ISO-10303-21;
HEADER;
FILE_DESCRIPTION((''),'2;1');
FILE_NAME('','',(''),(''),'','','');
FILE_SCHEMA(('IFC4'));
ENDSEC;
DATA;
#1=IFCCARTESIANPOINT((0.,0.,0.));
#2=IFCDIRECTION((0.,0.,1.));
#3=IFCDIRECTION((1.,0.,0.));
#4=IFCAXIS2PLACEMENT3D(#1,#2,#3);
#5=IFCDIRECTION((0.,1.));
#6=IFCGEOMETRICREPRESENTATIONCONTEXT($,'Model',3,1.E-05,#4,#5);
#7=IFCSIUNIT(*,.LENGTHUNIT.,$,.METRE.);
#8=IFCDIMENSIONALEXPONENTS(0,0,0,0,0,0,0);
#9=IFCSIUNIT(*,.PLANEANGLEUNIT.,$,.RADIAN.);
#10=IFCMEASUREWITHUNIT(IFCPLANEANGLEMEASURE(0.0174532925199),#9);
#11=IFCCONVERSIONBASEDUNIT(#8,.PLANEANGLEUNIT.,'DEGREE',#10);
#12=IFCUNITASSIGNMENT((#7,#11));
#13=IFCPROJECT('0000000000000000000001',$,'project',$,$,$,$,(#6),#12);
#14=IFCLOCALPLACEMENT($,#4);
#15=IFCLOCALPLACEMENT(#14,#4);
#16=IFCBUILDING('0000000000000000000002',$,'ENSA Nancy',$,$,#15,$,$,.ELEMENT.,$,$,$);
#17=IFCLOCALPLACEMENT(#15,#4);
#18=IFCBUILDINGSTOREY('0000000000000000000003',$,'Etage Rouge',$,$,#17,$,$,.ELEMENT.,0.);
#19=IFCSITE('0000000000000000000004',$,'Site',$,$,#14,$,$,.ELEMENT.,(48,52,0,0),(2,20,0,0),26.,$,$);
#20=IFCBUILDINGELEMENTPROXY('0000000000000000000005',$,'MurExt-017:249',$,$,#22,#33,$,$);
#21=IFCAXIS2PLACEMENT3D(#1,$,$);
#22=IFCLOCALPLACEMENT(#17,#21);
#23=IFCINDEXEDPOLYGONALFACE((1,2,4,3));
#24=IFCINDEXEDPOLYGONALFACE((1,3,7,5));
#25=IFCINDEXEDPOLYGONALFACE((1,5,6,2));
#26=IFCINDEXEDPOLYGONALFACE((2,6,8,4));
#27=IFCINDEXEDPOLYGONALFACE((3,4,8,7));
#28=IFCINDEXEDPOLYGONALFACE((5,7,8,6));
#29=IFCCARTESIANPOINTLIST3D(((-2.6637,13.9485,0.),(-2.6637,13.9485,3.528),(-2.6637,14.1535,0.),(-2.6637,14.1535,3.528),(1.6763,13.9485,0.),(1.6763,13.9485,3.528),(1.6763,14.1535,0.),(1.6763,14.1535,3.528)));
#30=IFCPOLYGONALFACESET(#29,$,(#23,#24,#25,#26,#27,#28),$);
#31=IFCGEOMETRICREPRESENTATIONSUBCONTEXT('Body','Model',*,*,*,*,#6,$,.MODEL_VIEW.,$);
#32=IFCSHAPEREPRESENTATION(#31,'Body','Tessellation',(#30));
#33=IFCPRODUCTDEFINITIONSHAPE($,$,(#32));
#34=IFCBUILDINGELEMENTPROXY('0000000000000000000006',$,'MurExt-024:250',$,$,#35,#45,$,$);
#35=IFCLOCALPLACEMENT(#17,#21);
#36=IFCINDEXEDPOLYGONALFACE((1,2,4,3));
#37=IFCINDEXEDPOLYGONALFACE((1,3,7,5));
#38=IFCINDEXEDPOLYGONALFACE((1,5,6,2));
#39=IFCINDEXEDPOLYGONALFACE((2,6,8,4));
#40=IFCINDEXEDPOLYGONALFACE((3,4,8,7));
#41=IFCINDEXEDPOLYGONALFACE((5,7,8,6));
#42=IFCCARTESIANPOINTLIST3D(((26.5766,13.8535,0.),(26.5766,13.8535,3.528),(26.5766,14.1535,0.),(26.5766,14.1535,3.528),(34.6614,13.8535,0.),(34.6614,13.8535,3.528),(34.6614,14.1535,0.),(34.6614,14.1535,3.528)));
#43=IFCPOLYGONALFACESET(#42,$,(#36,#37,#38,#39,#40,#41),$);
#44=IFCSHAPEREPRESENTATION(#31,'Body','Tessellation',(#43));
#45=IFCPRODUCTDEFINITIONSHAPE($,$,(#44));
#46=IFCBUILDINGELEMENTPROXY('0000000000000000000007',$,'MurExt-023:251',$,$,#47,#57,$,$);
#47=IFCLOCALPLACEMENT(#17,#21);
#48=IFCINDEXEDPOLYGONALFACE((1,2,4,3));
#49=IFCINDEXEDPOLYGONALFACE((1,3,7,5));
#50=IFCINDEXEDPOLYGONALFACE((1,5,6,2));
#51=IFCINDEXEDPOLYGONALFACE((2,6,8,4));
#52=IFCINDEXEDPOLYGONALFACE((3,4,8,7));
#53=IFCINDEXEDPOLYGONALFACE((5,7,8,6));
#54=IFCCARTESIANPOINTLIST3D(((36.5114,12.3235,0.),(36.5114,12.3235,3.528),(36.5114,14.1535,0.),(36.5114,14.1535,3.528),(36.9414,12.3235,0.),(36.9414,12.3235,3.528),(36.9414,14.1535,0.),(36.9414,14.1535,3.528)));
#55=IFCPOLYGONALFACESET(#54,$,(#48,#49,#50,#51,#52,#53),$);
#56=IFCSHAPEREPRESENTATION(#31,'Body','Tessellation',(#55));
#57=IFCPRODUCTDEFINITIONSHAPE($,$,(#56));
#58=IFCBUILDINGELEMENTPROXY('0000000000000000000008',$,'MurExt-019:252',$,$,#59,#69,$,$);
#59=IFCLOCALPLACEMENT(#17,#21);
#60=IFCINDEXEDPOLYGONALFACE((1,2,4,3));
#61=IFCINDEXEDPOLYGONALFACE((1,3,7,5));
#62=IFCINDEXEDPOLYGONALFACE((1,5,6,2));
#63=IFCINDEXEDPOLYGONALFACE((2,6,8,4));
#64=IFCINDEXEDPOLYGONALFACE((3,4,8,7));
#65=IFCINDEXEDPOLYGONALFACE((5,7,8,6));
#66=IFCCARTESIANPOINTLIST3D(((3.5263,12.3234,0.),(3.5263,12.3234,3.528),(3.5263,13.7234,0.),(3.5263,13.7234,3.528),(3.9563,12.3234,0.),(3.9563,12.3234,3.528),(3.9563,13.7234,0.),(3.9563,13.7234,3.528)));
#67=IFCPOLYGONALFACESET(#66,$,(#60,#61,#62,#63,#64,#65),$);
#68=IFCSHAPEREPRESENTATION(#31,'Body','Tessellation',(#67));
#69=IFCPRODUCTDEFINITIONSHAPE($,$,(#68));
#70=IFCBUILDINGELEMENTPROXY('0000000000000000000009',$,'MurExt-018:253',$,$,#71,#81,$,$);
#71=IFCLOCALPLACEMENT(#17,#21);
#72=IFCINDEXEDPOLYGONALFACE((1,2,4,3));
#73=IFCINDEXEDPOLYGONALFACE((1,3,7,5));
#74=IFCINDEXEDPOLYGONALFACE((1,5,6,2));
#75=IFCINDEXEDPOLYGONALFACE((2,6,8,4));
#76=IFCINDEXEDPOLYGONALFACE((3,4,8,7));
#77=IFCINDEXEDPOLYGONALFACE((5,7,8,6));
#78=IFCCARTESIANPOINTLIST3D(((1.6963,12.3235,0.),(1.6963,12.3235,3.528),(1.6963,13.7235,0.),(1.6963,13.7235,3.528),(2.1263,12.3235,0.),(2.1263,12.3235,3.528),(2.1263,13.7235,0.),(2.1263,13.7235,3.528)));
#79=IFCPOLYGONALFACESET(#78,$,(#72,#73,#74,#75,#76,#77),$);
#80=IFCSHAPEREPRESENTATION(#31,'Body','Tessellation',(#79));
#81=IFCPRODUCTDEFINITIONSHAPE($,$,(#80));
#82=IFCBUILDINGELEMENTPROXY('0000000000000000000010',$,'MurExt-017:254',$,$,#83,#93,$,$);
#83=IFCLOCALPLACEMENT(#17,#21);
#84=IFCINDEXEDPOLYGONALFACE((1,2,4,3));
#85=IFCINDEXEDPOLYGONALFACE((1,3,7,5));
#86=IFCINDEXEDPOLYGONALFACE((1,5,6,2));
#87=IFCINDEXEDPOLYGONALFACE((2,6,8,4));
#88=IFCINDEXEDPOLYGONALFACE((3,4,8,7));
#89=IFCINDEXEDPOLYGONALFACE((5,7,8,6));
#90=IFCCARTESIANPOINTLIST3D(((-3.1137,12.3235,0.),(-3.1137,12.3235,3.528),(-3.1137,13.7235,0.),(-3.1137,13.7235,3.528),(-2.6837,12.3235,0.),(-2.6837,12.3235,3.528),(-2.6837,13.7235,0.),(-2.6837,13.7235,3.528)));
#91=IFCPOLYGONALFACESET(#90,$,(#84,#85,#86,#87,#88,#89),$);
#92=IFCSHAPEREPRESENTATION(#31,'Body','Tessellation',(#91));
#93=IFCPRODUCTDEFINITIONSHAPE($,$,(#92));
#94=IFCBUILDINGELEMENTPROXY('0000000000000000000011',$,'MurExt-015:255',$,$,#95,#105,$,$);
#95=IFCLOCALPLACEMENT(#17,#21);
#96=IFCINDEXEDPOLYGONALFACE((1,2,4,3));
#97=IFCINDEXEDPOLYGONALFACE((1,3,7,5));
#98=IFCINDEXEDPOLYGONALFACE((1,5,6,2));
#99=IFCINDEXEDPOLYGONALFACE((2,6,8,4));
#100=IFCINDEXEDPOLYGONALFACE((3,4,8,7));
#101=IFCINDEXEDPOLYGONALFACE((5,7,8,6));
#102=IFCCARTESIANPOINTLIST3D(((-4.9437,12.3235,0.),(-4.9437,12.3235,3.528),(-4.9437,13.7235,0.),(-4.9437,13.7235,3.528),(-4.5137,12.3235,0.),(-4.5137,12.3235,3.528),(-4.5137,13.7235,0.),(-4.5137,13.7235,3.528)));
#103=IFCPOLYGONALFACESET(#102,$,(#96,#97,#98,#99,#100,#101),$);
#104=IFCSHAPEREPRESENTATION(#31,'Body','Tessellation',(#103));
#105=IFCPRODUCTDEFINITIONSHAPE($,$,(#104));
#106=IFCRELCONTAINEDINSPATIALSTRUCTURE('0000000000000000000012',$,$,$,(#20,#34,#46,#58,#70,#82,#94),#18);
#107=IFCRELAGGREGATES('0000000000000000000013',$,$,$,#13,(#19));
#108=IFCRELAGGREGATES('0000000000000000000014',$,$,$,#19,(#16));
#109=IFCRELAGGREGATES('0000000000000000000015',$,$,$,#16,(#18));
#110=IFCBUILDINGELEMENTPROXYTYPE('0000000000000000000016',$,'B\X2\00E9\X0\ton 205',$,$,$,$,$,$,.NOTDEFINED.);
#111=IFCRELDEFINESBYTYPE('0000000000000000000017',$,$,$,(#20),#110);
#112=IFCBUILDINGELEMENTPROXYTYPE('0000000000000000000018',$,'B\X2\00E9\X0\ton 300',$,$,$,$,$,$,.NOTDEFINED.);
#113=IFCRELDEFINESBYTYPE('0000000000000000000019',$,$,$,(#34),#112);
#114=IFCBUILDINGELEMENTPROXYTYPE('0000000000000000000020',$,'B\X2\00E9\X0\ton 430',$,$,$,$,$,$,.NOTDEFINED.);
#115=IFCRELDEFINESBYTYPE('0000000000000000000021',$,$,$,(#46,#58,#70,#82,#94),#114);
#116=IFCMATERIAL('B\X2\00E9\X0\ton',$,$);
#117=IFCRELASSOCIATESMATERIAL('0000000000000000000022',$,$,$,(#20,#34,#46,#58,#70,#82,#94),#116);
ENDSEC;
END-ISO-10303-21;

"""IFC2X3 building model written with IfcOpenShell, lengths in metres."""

from ifc_helpers import new_model, entity, si_unit, converted_unit, direction, frame, origin_with_axes, place, context, subcontext, project, spatial, polyline, outline, extrude, material, type_object, element, save


model = new_model("IFC2X3")

# Units and contexts
model_context = context("Model", 3, precision=1e-05, world=origin_with_axes(), true_north=direction((0.0, 1.0)))
body_context = subcontext(model_context, "Body", "Model", "MODEL_VIEW")
ifc_project = project(units=[si_unit("LENGTHUNIT", "METRE"), converted_unit("PLANEANGLEUNIT", "DEGREE", entity("IfcPlaneAngleMeasure", 0.0174532925199), si_unit("PLANEANGLEUNIT", "RADIAN"), dimensions=[0, 0, 0, 0, 0, 0, 0])], contexts=[model_context])

# Site, building, storey
site_placement = place(None, origin_with_axes())
site = spatial("IfcSite", under=ifc_project, at=site_placement, Name="Site", CompositionType="ELEMENT", RefLatitude=(48, 52, 0, 0), RefLongitude=(2, 20, 0, 0), RefElevation=26.0)
building_placement = place(site_placement, origin_with_axes())
building = spatial("IfcBuilding", under=site, at=building_placement, Name="ENSA Nancy", CompositionType="ELEMENT")
storey_placement = place(building_placement, origin_with_axes())
storey = spatial("IfcBuildingStorey", under=building, at=storey_placement, Name="Etage Rouge", CompositionType="ELEMENT", Elevation=0.0)

# Shared definitions
ifc_material = material(Name="Béton")

# Building element proxies
building_element_proxy_type_1 = type_object("IfcBuildingElementProxyType", Name="Béton 205", PredefinedType="NOTDEFINED")
proxy_1_placement = place(storey_placement, frame((1.6763, 14.1535, 0.0), z_axis=(0.0, 0.0, 1.0), x_axis=(-1.0, 0.0, 0.0)))
element("IfcBuildingElementProxy", 1, at=proxy_1_placement, inside=storey, type_object=building_element_proxy_type_1, material=ifc_material, Name="MurExt-017:249", context=body_context, shape_type="SweptSolid", body=[
    extrude(outline(polyline([(0.0, 0.0), (4.34, 0.0), (4.34, 0.205), (0.0, 0.205), (0.0, 0.0)])), origin_with_axes(), (0.0, 0.0, 1.0), 3.528),
])
building_element_proxy_type_2 = type_object("IfcBuildingElementProxyType", Name="Béton 300", PredefinedType="NOTDEFINED")
proxy_2_placement = place(storey_placement, frame((26.5766, 13.8535, 0.0), z_axis=(0.0, 0.0, 1.0), x_axis=(1.0, 0.0, 0.0)))
element("IfcBuildingElementProxy", 2, at=proxy_2_placement, inside=storey, type_object=building_element_proxy_type_2, material=ifc_material, Name="MurExt-024:250", context=body_context, shape_type="SweptSolid", body=[
    extrude(outline(polyline([(0.0, 0.0), (8.0848, 0.0), (8.0848, 0.3), (0.0, 0.3), (0.0, 0.0)])), origin_with_axes(), (0.0, 0.0, 1.0), 3.528),
])
building_element_proxy_type_3 = type_object("IfcBuildingElementProxyType", Name="Béton 430", PredefinedType="NOTDEFINED")
proxy_3_placement = place(storey_placement, frame((36.5114, 14.1535, 0.0), z_axis=(0.0, 0.0, 1.0), x_axis=(0.0, -1.0, 0.0)))
element("IfcBuildingElementProxy", 3, at=proxy_3_placement, inside=storey, type_object=building_element_proxy_type_3, material=ifc_material, Name="MurExt-023:251", context=body_context, shape_type="SweptSolid", body=[
    extrude(outline(polyline([(0.0, 0.0), (1.83, 0.0), (1.83, 0.43), (0.0, 0.43), (0.0, 0.0)])), origin_with_axes(), (0.0, 0.0, 1.0), 3.528),
])
for number, where, z_axis, x_axis, name in (
    (4, (3.5263, 13.7234, 0.0), (0.0, 0.0, 1.0), (0.0, -1.0, 0.0), "MurExt-019:252"),
    (5, (1.6963, 13.7235, 0.0), (0.0, 0.0, 1.0), (0.0, -1.0, 0.0), "MurExt-018:253"),
):
    element("IfcBuildingElementProxy", number, at=place(storey_placement, frame(where, z_axis=z_axis, x_axis=x_axis)), inside=storey, type_object=building_element_proxy_type_3, material=ifc_material, Name=name, context=body_context, shape_type="SweptSolid", body=[
        extrude(outline(polyline([(0.0, 0.0), (1.4, 0.0), (1.4, 0.43), (0.0, 0.43), (0.0, 0.0)])), origin_with_axes(), (0.0, 0.0, 1.0), 3.528),
    ])
proxy_4_placement = place(storey_placement, frame((-3.1137, 13.7235, 0.0), z_axis=(0.0, 0.0, 1.0), x_axis=(0.0, -1.0, 0.0)))
element("IfcBuildingElementProxy", 6, at=proxy_4_placement, inside=storey, type_object=building_element_proxy_type_3, material=ifc_material, Name="MurExt-017:254", context=body_context, shape_type="SweptSolid", body=[
    extrude(outline(polyline([(0.0, 0.0), (1.4, 0.0), (1.4, 0.43), (0.0, 0.43), (0.0, 0.0)])), origin_with_axes(), (0.0, 0.0, 1.0), 3.528),
])
proxy_5_placement = place(storey_placement, frame((-4.9437, 13.7235, 0.0), z_axis=(0.0, 0.0, 1.0), x_axis=(0.0, -1.0, 0.0)))
element("IfcBuildingElementProxy", 7, at=proxy_5_placement, inside=storey, type_object=building_element_proxy_type_3, material=ifc_material, Name="MurExt-015:255", context=body_context, shape_type="SweptSolid", body=[
    extrude(outline(polyline([(0.0, 0.0), (1.4, 0.0), (1.4, 0.43), (0.0, 0.43), (0.0, 0.0)])), origin_with_axes(), (0.0, 0.0, 1.0), 3.528),
])

save(model, "model.ifc")
